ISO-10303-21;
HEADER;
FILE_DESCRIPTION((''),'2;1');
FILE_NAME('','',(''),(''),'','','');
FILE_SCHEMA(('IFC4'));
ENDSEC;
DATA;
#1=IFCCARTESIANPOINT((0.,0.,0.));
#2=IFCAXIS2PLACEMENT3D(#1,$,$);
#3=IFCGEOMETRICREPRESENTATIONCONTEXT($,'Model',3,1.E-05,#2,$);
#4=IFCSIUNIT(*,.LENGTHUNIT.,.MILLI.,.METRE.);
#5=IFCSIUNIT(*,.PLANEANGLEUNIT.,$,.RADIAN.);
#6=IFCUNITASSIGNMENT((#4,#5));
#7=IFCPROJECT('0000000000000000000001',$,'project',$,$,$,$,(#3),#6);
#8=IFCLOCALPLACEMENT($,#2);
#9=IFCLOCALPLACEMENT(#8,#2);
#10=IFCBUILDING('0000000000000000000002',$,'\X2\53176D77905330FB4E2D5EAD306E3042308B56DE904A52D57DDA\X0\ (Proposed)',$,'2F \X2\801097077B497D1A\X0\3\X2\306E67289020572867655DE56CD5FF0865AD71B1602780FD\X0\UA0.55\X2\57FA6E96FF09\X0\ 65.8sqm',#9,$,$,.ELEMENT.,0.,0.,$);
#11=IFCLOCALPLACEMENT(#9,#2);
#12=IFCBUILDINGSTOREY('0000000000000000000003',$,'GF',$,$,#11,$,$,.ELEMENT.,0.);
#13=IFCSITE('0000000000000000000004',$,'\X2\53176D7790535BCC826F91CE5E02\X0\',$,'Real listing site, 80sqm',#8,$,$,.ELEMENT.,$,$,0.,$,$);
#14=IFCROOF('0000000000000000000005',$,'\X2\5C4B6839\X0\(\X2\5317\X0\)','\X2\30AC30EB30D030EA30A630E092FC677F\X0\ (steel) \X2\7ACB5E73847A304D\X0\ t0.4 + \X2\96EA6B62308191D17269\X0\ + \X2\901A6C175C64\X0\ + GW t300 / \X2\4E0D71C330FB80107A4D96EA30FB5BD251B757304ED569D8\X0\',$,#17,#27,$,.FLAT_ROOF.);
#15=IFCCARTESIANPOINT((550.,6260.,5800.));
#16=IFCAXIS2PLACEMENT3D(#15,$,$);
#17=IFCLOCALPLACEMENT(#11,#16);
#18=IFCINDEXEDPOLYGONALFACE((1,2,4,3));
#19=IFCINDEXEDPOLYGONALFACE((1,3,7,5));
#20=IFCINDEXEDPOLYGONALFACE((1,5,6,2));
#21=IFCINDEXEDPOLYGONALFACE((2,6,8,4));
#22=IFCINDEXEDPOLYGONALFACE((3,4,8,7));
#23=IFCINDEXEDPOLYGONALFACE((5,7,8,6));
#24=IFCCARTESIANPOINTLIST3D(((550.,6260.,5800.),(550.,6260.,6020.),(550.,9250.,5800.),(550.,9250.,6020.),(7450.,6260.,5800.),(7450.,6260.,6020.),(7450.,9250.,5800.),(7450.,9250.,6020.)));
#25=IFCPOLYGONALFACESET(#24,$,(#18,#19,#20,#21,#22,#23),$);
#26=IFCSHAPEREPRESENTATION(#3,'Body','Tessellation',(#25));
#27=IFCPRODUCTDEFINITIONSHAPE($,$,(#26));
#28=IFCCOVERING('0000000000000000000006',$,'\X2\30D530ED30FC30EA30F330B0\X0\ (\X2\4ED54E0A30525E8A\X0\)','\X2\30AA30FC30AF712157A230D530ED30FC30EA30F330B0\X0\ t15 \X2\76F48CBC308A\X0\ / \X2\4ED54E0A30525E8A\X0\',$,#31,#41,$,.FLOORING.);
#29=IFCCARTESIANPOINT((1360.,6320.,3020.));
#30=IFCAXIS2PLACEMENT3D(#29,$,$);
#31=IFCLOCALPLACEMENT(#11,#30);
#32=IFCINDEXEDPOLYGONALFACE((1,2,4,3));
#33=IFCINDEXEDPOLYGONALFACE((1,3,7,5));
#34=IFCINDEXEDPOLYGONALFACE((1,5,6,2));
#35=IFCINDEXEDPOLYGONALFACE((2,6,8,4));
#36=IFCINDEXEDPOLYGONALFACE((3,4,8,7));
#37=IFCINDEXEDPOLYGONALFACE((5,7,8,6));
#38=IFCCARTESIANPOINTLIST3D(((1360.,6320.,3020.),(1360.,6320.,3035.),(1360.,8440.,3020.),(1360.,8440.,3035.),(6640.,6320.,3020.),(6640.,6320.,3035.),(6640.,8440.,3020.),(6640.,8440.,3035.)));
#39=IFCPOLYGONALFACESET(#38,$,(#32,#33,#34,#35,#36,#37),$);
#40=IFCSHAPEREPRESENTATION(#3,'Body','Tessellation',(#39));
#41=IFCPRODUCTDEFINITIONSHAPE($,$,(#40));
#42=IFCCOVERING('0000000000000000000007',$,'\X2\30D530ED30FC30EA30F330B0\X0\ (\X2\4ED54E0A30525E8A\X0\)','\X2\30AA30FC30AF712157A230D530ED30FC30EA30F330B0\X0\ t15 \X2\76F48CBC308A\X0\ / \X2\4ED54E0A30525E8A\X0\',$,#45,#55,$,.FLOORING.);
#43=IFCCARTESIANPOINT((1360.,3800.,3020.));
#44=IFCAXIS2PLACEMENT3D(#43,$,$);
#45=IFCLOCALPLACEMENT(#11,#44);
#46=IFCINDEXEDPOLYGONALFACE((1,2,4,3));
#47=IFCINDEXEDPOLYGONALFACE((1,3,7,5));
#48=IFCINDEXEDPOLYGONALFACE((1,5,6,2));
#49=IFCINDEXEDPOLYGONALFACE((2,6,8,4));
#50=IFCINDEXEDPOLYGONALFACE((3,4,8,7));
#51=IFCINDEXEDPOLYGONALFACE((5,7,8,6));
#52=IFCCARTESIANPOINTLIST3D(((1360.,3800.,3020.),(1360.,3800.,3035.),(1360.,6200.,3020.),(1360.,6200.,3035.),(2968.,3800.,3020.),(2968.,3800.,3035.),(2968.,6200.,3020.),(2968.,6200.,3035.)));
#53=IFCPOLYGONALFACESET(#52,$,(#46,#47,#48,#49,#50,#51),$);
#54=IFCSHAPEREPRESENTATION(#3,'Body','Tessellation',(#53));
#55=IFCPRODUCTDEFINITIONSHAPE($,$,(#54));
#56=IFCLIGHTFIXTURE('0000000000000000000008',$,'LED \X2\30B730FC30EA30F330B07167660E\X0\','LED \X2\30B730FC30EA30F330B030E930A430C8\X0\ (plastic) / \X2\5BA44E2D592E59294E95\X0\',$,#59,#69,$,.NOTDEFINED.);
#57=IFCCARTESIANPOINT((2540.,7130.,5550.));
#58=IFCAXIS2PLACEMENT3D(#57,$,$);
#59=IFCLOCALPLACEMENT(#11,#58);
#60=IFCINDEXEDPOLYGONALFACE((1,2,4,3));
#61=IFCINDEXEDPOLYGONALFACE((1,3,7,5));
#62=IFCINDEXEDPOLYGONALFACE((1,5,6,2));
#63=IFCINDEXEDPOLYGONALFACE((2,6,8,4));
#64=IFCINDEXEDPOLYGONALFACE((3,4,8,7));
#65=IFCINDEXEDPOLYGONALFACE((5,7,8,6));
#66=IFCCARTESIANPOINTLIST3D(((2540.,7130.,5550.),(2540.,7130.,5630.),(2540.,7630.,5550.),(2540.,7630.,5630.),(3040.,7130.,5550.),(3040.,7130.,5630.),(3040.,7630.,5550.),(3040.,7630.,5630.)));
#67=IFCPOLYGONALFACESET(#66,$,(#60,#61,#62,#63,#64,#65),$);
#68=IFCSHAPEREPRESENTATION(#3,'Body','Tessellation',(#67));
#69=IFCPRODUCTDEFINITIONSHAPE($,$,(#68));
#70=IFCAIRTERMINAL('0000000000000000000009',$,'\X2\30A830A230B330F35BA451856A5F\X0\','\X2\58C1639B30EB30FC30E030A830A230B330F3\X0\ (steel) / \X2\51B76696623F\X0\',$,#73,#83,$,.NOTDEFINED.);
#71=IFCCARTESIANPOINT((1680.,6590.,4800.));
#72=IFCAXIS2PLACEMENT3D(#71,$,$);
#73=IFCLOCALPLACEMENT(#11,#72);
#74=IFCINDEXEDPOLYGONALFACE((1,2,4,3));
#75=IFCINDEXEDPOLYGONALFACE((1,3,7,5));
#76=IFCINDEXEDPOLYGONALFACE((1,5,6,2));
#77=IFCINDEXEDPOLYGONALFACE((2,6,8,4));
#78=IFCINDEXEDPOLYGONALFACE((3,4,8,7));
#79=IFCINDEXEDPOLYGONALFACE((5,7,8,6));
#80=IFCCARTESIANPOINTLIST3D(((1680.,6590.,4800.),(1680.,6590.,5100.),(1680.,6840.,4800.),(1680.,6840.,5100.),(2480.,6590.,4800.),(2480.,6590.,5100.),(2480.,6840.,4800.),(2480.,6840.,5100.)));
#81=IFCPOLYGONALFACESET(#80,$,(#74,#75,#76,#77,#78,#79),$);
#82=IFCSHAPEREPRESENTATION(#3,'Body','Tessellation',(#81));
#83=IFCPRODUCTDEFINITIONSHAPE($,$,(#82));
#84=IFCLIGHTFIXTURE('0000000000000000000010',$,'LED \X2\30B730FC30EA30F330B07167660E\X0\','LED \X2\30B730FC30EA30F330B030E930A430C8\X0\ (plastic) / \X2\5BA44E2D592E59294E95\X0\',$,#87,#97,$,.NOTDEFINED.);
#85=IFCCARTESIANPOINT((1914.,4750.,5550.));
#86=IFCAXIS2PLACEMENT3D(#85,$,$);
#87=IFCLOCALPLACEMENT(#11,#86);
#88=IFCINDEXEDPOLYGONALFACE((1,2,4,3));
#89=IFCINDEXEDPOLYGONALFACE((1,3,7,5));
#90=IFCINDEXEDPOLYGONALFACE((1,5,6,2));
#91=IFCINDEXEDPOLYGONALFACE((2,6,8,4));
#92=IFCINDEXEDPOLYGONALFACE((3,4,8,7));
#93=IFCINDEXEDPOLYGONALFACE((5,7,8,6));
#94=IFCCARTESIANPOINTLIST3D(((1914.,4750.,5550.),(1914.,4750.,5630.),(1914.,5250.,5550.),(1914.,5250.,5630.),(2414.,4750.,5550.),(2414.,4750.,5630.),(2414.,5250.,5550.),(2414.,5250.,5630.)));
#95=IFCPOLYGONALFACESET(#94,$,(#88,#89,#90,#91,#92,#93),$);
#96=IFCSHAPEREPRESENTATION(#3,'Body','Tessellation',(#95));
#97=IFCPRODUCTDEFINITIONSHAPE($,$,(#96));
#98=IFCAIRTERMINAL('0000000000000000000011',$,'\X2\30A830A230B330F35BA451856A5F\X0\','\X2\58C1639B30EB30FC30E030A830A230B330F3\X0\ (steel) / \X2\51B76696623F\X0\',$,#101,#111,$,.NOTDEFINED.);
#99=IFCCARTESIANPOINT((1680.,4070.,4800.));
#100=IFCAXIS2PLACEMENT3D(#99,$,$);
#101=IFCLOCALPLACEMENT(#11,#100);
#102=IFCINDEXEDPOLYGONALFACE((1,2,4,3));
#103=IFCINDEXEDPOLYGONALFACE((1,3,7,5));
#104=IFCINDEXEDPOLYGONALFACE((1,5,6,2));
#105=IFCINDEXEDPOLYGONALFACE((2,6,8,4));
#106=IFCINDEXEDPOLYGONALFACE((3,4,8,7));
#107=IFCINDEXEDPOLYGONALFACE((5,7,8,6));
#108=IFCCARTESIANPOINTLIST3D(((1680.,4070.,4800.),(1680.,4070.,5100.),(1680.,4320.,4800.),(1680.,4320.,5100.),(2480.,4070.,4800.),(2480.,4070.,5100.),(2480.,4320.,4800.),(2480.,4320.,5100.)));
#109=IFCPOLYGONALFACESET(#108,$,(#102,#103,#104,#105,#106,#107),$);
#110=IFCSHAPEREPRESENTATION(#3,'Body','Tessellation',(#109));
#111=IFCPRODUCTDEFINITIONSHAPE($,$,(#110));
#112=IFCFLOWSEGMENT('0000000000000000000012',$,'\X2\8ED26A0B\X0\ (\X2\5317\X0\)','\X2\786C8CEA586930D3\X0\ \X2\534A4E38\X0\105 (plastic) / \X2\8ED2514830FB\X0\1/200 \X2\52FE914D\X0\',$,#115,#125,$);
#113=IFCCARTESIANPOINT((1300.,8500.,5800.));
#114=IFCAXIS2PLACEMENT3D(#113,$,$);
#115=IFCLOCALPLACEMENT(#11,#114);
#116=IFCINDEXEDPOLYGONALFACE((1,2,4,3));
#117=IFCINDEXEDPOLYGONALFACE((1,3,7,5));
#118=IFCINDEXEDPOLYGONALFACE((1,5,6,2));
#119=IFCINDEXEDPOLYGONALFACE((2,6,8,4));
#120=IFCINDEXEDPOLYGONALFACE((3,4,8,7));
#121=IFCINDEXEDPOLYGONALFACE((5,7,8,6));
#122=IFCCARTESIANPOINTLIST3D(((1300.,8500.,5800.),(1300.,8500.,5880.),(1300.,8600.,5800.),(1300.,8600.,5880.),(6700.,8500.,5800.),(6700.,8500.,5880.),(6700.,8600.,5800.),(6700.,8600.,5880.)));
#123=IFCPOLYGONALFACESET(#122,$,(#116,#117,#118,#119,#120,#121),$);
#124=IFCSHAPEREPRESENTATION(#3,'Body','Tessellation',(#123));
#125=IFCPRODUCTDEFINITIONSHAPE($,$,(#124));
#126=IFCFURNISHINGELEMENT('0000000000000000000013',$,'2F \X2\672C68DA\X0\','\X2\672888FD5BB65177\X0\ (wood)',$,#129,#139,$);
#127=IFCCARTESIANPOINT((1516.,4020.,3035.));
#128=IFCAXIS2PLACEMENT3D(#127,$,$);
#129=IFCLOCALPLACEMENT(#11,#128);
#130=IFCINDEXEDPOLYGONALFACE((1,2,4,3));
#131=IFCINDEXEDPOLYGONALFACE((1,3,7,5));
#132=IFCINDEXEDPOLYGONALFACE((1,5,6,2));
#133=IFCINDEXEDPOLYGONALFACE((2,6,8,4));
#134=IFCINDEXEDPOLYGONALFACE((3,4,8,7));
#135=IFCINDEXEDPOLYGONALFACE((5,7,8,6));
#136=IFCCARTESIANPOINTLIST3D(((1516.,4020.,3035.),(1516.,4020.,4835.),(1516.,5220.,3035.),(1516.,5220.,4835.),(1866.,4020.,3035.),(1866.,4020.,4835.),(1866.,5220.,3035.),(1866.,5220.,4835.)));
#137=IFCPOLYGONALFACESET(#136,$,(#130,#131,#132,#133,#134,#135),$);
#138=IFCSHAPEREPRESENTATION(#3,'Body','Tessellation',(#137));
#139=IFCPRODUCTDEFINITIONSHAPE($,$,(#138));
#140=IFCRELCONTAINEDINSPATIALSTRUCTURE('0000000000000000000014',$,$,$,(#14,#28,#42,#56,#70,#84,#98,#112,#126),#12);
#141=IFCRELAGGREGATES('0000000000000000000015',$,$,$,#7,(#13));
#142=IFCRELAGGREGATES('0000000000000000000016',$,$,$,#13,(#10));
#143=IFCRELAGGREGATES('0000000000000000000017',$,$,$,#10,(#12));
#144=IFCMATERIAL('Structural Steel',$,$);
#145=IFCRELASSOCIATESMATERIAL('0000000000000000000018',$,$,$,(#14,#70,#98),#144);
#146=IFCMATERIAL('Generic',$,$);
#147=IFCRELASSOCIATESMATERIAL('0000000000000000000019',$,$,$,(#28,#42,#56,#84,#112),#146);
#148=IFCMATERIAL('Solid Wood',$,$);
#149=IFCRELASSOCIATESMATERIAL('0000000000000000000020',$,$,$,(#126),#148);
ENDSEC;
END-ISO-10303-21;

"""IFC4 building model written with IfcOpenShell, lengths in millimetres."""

from ifc_helpers import new_model, si_unit, frame, frame_2d, origin, place, context, project, spatial, rectangle, extrude, material, element, save


model = new_model("IFC4")

# Units and contexts
model_context = context("Model", 3, precision=1e-05, world=origin())
ifc_project = project(units=[si_unit("LENGTHUNIT", "METRE", prefix="MILLI"), si_unit("PLANEANGLEUNIT", "RADIAN")], contexts=[model_context])

# Site, building, storey
site_placement = place(None, origin())
site = spatial("IfcSite", under=ifc_project, at=site_placement, Name="北海道富良野市", ObjectType="Real listing site, 80sqm", CompositionType="ELEMENT", RefElevation=0.0)
building_placement = place(site_placement, origin())
building = spatial("IfcBuilding", under=site, at=building_placement, Name="北海道・中庭のある回遊動線 (Proposed)", ObjectType="2F 耐震等級3の木造在来工法（断熱性能UA0.55基準） 65.8sqm", CompositionType="ELEMENT", ElevationOfRefHeight=0.0, ElevationOfTerrain=0.0)
storey_placement = place(building_placement, origin())
storey = spatial("IfcBuildingStorey", under=building, at=storey_placement, Name="GF", CompositionType="ELEMENT", Elevation=0.0)

# Shared definitions
ifc_material_1 = material(Name="Solid Wood")

# Roof
ifc_material_2 = material(Name="Structural Steel")
for number, where, name in (
    (1, (550.0, 6260.0, 5800.0), "屋根(北)"),
):
    element("IfcRoof", number, at=place(storey_placement, frame(where)), inside=storey, material=ifc_material_2, Name=name, Description="ガルバリウム鋼板 (steel) 立平葺き t0.4 + 雪止め金物 + 通気層 + GW t300 / 不燃・耐積雪・寒冷地仕様", PredefinedType="FLAT_ROOF", context=model_context, shape_type="SweptSolid", body=[
        extrude(rectangle(XDim=6900.0, YDim=2990.0, at=frame_2d((3450.0, 1495.0))), frame((550.0, 6260.0, 5800.0)), (0.0, 0.0, 1.0), 220.0),
    ])

# Coverings
ifc_material_3 = material(Name="Generic")
covering_1_placement = place(storey_placement, frame((1360.0, 6320.0, 3020.0)))
element("IfcCovering", 2, at=covering_1_placement, inside=storey, material=ifc_material_3, Name="フローリング (仕上げ床)", Description="オーク無垢フローリング t15 直貼り / 仕上げ床", PredefinedType="FLOORING", context=model_context, shape_type="SweptSolid", body=[
    extrude(rectangle(XDim=5280.0, YDim=2120.0, at=frame_2d((2640.0, 1060.0))), frame((1360.0, 6320.0, 3020.0)), (0.0, 0.0, 1.0), 15.0),
])
covering_2_placement = place(storey_placement, frame((1360.0, 3800.0, 3020.0)))
element("IfcCovering", 3, at=covering_2_placement, inside=storey, material=ifc_material_3, Name="フローリング (仕上げ床)", Description="オーク無垢フローリング t15 直貼り / 仕上げ床", PredefinedType="FLOORING", context=model_context, shape_type="SweptSolid", body=[
    extrude(rectangle(XDim=1608.0, YDim=2400.0, at=frame_2d((804.0, 1200.0))), frame((1360.0, 3800.0, 3020.0)), (0.0, 0.0, 1.0), 15.0),
])

# Light fixture
light_fixture_1_placement = place(storey_placement, frame((2540.0, 7130.0, 5550.0)))
element("IfcLightFixture", 4, at=light_fixture_1_placement, inside=storey, material=ifc_material_3, Name="LED シーリング照明", Description="LED シーリングライト (plastic) / 室中央天井", PredefinedType="NOTDEFINED", context=model_context, shape_type="SweptSolid", body=[
    extrude(rectangle(XDim=500.0, YDim=500.0, at=frame_2d((250.0, 250.0))), frame((2540.0, 7130.0, 5550.0)), (0.0, 0.0, 1.0), 80.0),
])

# Air terminal
air_terminal_1_placement = place(storey_placement, frame((1680.0, 6590.0, 4800.0)))
element("IfcAirTerminal", 5, at=air_terminal_1_placement, inside=storey, material=ifc_material_2, Name="エアコン室内機", Description="壁掛ルームエアコン (steel) / 冷暖房", PredefinedType="NOTDEFINED", context=model_context, shape_type="SweptSolid", body=[
    extrude(rectangle(XDim=800.0, YDim=250.0, at=frame_2d((400.0, 125.0))), frame((1680.0, 6590.0, 4800.0)), (0.0, 0.0, 1.0), 300.0),
])

# Light fixture
light_fixture_2_placement = place(storey_placement, frame((1914.0, 4750.0, 5550.0)))
element("IfcLightFixture", 6, at=light_fixture_2_placement, inside=storey, material=ifc_material_3, Name="LED シーリング照明", Description="LED シーリングライト (plastic) / 室中央天井", PredefinedType="NOTDEFINED", context=model_context, shape_type="SweptSolid", body=[
    extrude(rectangle(XDim=500.0, YDim=500.0, at=frame_2d((250.0, 250.0))), frame((1914.0, 4750.0, 5550.0)), (0.0, 0.0, 1.0), 80.0),
])

# Air terminal
air_terminal_2_placement = place(storey_placement, frame((1680.0, 4070.0, 4800.0)))
element("IfcAirTerminal", 7, at=air_terminal_2_placement, inside=storey, material=ifc_material_2, Name="エアコン室内機", Description="壁掛ルームエアコン (steel) / 冷暖房", PredefinedType="NOTDEFINED", context=model_context, shape_type="SweptSolid", body=[
    extrude(rectangle(XDim=800.0, YDim=250.0, at=frame_2d((400.0, 125.0))), frame((1680.0, 4070.0, 4800.0)), (0.0, 0.0, 1.0), 300.0),
])

# Flow segment
flow_segment_placement = place(storey_placement, frame((1300.0, 8500.0, 5800.0)))
element("IfcFlowSegment", 8, at=flow_segment_placement, inside=storey, material=ifc_material_3, Name="軒樋 (北)", Description="硬質塩ビ 半丸105 (plastic) / 軒先・1/200 勾配", context=model_context, shape_type="SweptSolid", body=[
    extrude(rectangle(XDim=5400.0, YDim=100.0, at=frame_2d((2700.0, 50.0))), frame((1300.0, 8500.0, 5800.0)), (0.0, 0.0, 1.0), 80.0),
])

# Furnishing element
furnishing_placement = place(storey_placement, frame((1516.0, 4020.0, 3035.0)))
element("IfcFurnishingElement", 9, at=furnishing_placement, inside=storey, material=ifc_material_1, Name="2F 本棚", Description="木製家具 (wood)", context=model_context, shape_type="SweptSolid", body=[
    extrude(rectangle(XDim=350.0, YDim=1200.0, at=frame_2d((175.0, 600.0))), frame((1516.0, 4020.0, 3035.0)), (0.0, 0.0, 1.0), 1800.0),
])

save(model, "model.ifc")
